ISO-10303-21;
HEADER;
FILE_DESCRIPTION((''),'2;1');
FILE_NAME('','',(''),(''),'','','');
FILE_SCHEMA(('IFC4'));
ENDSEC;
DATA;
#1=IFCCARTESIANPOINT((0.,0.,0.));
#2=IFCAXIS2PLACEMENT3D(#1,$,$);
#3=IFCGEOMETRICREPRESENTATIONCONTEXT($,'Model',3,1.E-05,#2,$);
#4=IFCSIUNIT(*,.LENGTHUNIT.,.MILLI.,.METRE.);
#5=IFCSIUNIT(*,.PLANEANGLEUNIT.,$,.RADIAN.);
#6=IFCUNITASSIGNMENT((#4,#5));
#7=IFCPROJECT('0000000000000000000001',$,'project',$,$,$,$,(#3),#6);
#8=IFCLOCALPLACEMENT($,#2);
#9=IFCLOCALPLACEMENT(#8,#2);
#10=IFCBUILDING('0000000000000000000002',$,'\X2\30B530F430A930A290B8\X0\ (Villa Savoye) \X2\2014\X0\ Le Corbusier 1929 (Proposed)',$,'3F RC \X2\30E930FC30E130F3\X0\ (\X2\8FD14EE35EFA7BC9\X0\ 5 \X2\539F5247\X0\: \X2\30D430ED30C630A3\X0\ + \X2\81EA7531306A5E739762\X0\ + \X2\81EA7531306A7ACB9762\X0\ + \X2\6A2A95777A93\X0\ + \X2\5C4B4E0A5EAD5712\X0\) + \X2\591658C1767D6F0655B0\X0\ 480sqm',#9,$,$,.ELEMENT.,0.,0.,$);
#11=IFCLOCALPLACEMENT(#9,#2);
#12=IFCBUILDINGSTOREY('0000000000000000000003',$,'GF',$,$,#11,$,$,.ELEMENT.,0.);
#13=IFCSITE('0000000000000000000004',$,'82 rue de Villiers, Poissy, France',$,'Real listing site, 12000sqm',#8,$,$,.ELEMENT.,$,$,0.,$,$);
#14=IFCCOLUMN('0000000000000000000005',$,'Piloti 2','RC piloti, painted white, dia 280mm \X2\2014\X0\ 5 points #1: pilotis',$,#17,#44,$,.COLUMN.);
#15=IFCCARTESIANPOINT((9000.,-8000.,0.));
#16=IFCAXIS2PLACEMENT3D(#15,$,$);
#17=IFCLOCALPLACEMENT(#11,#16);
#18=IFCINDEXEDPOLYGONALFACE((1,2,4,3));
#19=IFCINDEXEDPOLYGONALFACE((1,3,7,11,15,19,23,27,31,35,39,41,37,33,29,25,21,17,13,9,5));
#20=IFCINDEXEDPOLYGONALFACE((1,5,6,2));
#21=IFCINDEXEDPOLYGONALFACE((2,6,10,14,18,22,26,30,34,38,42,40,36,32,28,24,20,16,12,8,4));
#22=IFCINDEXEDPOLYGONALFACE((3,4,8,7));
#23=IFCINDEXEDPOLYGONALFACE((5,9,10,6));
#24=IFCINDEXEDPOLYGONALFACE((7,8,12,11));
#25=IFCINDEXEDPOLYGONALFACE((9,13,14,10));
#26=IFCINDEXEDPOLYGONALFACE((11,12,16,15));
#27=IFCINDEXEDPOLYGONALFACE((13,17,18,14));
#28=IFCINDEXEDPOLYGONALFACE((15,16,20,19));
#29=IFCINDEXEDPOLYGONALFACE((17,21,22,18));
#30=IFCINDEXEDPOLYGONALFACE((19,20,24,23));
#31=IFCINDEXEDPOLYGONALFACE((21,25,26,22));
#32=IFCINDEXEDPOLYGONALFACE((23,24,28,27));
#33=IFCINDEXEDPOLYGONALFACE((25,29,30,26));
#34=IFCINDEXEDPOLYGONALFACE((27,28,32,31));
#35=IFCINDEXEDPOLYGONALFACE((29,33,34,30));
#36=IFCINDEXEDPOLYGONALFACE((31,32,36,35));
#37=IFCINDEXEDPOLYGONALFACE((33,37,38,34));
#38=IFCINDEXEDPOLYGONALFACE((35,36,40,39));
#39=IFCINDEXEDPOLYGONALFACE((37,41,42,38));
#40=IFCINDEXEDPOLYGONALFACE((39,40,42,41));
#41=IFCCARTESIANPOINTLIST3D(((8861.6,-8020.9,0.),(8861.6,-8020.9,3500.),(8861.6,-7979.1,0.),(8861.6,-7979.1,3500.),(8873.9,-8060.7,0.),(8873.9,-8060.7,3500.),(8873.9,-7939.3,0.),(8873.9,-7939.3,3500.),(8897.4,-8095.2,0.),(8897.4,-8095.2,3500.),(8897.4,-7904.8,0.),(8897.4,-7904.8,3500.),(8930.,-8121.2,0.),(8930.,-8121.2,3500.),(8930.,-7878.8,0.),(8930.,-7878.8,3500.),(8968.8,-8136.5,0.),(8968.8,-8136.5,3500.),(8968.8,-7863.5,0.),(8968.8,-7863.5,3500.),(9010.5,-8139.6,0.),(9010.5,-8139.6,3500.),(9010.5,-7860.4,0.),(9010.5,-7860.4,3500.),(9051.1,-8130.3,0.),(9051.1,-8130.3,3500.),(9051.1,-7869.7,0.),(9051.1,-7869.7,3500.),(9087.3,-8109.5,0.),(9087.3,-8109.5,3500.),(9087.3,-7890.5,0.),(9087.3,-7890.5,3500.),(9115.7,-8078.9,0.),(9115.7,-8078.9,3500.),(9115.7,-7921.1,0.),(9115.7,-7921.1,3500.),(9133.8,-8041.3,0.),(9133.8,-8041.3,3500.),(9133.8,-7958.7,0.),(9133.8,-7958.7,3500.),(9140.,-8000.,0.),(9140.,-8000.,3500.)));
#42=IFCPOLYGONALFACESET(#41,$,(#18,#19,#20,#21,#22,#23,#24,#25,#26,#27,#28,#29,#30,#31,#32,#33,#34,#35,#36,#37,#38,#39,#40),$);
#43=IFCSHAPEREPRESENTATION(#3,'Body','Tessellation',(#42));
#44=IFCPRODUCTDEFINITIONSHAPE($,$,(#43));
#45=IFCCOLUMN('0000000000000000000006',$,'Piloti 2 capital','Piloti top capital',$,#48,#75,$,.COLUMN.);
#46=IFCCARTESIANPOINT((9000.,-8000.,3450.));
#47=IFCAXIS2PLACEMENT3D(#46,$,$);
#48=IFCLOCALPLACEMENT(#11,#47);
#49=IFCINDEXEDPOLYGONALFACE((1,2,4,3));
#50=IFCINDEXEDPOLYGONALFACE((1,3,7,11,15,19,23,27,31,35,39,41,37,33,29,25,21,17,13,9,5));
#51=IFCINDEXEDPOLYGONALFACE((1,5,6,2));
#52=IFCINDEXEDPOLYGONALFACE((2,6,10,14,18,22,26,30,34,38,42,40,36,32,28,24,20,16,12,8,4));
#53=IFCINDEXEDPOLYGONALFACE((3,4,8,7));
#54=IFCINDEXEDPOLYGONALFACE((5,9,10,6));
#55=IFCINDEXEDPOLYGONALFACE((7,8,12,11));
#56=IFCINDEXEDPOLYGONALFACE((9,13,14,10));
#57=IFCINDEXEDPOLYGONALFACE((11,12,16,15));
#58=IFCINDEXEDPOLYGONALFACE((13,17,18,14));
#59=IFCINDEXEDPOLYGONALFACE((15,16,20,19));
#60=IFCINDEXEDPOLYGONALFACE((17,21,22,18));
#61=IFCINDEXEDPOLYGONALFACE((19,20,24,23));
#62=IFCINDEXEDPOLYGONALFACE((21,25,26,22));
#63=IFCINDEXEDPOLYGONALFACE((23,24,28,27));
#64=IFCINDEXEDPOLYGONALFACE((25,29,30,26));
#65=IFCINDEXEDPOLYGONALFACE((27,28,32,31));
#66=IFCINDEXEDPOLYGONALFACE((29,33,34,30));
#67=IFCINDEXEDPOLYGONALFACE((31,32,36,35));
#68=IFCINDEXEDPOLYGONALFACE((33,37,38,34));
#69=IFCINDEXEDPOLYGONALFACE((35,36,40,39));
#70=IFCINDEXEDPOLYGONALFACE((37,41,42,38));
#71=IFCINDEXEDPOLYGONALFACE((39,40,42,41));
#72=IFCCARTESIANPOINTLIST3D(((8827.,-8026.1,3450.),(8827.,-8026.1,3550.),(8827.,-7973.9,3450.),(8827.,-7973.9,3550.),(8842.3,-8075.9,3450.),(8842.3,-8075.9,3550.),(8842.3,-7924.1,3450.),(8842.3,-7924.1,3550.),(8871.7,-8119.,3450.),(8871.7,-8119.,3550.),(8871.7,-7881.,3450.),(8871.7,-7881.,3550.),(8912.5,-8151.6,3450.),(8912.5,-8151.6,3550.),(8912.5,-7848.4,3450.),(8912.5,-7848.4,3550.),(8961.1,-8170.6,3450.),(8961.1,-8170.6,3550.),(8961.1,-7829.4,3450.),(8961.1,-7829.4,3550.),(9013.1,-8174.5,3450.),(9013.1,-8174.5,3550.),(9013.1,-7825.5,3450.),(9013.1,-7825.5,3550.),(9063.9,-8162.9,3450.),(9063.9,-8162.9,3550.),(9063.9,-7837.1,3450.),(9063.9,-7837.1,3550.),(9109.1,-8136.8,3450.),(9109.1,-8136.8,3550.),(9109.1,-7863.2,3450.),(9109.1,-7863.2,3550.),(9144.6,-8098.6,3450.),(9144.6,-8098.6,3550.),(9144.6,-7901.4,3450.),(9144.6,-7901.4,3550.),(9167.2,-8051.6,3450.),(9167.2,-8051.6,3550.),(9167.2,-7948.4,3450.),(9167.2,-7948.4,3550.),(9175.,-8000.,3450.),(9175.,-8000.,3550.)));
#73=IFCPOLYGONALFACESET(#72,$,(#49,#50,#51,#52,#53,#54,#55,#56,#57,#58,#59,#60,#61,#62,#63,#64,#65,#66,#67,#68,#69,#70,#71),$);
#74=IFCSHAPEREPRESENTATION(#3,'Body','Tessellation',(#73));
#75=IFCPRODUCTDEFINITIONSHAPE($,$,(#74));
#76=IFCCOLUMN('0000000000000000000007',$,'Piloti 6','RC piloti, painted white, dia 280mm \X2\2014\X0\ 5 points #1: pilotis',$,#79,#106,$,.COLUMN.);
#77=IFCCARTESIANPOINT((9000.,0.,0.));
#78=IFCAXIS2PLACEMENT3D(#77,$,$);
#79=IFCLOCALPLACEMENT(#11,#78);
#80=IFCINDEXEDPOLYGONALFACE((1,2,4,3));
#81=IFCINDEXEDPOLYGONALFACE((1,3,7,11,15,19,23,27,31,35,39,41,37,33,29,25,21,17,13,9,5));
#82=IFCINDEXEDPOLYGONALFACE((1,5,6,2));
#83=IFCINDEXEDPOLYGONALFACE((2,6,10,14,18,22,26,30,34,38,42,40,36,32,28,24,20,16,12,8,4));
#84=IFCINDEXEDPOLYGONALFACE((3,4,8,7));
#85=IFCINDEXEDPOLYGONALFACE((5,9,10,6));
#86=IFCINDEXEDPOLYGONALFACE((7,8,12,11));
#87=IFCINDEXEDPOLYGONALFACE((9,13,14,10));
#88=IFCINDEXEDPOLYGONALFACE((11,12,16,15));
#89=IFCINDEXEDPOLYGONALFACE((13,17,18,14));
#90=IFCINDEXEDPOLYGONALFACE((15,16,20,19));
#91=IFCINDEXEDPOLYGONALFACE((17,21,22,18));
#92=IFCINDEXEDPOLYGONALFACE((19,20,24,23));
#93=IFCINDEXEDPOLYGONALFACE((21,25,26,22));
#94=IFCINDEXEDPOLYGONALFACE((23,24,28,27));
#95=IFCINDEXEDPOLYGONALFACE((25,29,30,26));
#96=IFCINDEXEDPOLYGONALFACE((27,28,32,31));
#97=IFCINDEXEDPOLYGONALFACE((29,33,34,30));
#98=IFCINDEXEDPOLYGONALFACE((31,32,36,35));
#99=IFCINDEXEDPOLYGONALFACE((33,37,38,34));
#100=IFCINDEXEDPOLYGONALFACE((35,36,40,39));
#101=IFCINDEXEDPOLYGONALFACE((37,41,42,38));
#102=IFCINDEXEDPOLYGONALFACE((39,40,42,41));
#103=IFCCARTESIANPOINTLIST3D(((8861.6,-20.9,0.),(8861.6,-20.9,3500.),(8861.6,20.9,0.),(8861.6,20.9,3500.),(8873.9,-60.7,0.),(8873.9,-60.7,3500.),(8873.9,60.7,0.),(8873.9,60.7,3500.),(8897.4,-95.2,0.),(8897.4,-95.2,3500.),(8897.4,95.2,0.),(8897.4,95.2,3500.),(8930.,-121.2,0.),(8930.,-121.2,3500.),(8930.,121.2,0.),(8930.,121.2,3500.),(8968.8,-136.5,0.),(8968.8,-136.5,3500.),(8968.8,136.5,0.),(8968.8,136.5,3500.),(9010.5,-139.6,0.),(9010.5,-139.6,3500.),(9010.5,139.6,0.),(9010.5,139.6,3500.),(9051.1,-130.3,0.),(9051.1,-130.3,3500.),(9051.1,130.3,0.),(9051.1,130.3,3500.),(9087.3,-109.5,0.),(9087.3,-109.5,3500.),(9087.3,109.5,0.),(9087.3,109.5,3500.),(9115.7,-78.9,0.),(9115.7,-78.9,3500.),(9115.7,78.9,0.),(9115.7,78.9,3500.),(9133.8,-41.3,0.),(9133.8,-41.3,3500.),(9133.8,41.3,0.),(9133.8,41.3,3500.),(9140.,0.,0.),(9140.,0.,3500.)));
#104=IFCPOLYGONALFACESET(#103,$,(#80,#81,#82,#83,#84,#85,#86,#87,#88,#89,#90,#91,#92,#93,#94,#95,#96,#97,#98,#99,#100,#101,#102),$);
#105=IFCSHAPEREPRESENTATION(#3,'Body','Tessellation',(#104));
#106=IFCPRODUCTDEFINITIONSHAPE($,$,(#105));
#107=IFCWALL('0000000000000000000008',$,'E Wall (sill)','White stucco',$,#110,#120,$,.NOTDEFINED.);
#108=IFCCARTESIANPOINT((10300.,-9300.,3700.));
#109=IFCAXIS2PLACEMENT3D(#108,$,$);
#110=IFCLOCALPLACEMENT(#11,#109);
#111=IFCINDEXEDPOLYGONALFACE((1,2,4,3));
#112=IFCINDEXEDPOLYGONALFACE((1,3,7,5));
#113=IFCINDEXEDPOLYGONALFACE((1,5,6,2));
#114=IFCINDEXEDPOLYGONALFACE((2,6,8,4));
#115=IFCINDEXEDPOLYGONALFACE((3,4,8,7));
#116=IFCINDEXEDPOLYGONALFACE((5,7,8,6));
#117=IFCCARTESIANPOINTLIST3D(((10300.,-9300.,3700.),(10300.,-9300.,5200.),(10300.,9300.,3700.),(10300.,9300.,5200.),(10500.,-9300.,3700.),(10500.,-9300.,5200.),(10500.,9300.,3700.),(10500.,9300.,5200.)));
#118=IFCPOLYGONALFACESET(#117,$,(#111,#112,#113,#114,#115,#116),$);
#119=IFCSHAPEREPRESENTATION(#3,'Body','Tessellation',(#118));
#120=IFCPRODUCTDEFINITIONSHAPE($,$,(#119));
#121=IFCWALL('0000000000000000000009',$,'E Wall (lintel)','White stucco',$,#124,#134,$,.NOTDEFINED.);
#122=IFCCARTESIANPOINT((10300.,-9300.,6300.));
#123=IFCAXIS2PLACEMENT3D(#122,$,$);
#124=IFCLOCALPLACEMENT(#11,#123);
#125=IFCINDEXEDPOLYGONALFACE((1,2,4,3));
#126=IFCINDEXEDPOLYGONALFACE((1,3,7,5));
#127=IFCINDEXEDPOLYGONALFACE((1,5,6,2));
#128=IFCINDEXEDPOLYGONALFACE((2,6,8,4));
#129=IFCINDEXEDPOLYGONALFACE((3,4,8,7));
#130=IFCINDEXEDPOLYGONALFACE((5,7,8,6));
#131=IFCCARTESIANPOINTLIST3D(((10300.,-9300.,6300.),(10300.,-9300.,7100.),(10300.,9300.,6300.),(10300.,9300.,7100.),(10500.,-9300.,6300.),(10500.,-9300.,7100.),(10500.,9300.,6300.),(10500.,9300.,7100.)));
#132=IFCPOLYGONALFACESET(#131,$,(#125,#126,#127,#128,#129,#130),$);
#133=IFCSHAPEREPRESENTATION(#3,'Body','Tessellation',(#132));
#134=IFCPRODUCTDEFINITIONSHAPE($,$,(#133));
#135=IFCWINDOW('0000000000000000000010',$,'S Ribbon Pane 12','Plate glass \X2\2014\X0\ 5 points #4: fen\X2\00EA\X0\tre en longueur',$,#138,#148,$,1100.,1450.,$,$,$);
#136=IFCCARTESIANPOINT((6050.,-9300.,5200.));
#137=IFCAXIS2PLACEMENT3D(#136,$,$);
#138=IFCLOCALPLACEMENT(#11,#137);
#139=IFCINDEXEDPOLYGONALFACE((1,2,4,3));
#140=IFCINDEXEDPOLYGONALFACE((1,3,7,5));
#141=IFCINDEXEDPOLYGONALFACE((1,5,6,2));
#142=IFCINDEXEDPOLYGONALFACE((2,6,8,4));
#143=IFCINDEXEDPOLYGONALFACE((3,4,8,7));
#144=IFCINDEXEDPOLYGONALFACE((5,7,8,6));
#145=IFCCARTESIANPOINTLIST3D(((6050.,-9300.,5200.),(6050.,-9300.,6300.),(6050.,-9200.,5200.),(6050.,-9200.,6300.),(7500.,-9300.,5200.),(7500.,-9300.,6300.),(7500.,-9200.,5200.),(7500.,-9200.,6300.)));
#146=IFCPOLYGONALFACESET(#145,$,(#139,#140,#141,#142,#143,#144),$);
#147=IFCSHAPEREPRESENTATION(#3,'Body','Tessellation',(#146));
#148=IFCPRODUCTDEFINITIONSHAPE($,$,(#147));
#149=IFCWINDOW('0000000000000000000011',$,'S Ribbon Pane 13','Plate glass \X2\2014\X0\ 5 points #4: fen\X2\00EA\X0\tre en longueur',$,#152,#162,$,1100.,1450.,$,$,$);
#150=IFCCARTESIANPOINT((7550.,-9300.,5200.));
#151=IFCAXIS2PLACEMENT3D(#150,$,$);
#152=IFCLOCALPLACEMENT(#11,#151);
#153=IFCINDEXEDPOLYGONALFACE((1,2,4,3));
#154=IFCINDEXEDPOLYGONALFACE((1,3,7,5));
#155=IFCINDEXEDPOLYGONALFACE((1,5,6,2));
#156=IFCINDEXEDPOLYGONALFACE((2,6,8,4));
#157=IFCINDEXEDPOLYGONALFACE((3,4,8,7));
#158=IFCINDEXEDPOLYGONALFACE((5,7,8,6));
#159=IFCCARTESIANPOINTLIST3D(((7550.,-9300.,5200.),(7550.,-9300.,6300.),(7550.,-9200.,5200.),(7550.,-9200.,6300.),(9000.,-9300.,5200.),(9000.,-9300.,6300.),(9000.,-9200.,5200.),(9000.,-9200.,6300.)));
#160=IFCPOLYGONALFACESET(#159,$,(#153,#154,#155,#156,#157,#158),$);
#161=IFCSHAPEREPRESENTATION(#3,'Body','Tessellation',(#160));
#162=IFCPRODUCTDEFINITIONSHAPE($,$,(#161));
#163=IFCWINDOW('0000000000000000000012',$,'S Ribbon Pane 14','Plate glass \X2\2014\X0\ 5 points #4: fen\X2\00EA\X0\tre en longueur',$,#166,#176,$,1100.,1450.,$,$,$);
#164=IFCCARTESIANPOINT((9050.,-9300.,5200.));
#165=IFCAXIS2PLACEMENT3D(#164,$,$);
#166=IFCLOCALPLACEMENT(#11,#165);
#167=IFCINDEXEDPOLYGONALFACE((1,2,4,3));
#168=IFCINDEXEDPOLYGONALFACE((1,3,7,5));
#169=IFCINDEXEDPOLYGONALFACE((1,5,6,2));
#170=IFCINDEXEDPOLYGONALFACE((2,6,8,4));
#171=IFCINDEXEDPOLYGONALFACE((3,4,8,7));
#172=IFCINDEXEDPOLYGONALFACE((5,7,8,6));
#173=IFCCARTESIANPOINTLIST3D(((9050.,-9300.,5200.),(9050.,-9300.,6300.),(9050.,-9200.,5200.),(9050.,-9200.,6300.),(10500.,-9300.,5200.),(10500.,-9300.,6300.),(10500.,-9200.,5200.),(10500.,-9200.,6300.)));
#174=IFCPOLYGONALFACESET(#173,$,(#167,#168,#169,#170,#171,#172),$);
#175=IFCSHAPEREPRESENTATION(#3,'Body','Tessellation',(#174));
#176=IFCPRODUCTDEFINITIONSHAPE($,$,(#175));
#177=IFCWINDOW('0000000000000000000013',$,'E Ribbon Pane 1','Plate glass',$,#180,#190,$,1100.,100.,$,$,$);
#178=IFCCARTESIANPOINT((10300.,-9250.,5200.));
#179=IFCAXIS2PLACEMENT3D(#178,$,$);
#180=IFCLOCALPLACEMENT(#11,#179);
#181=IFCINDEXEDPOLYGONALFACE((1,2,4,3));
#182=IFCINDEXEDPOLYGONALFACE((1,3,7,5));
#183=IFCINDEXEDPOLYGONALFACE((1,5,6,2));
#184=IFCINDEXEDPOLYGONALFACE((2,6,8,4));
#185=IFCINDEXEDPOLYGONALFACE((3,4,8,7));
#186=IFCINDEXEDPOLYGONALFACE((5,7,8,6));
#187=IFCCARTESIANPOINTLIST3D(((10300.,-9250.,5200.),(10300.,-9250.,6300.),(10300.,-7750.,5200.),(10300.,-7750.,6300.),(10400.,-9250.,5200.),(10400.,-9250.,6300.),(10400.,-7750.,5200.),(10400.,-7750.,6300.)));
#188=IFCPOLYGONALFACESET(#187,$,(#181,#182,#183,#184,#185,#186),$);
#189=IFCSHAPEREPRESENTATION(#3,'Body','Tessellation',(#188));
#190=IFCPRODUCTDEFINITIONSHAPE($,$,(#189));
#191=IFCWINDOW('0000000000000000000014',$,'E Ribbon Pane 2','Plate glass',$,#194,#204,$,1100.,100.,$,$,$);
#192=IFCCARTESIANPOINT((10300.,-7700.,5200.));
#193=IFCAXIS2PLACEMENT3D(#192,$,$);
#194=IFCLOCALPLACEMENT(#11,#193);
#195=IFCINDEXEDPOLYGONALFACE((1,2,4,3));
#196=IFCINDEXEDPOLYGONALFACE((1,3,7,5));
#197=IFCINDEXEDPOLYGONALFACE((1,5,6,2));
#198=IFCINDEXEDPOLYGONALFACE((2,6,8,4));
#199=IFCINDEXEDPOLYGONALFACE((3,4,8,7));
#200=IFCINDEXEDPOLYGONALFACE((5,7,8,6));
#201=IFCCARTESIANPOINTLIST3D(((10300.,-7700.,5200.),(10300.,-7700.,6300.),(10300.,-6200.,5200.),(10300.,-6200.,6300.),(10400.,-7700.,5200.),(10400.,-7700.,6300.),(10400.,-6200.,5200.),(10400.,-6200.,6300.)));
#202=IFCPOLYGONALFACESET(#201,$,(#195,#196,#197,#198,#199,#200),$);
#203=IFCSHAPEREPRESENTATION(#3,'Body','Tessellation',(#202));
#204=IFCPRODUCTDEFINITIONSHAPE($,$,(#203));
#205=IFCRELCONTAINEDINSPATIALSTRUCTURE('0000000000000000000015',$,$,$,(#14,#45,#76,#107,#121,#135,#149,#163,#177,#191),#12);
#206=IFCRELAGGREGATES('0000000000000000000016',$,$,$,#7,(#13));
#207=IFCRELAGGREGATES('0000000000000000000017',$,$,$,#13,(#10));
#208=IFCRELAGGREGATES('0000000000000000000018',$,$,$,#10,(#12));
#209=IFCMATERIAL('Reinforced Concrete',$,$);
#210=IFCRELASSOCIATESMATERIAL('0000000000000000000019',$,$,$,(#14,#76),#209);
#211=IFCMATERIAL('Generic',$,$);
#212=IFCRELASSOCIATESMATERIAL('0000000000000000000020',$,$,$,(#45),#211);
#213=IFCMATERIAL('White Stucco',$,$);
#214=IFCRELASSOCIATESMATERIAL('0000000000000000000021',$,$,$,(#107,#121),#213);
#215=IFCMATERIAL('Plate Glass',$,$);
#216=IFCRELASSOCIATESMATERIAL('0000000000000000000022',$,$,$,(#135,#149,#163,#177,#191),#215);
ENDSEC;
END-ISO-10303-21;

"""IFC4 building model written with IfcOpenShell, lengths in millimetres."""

from ifc_helpers import new_model, si_unit, frame, frame_2d, origin, origin_2d, place, context, project, spatial, rectangle, circle, extrude, material, element, save


model = new_model("IFC4")

# Units and contexts
model_context = context("Model", 3, precision=1e-05, world=origin())
ifc_project = project(units=[si_unit("LENGTHUNIT", "METRE", prefix="MILLI"), si_unit("PLANEANGLEUNIT", "RADIAN")], contexts=[model_context])

# Site, building, storey
site_placement = place(None, origin())
site = spatial("IfcSite", under=ifc_project, at=site_placement, Name="82 rue de Villiers, Poissy, France", ObjectType="Real listing site, 12000sqm", CompositionType="ELEMENT", RefElevation=0.0)
building_placement = place(site_placement, origin())
building = spatial("IfcBuilding", under=site, at=building_placement, Name="サヴォア邸 (Villa Savoye) — Le Corbusier 1929 (Proposed)", ObjectType="3F RC ラーメン (近代建築 5 原則: ピロティ + 自由な平面 + 自由な立面 + 横長窓 + 屋上庭園) + 外壁白漆喰 480sqm", CompositionType="ELEMENT", ElevationOfRefHeight=0.0, ElevationOfTerrain=0.0)
storey_placement = place(building_placement, origin())
storey = spatial("IfcBuildingStorey", under=building, at=storey_placement, Name="GF", CompositionType="ELEMENT", Elevation=0.0)

# Columns
ifc_material_1 = material(Name="Reinforced Concrete")
column_1_placement = place(storey_placement, frame((9000.0, -8000.0, 0.0)))
element("IfcColumn", 1, at=column_1_placement, inside=storey, material=ifc_material_1, Name="Piloti 2", Description="RC piloti, painted white, dia 280mm — 5 points #1: pilotis", PredefinedType="COLUMN", context=model_context, shape_type="SweptSolid", body=[
    extrude(circle(Radius=140.0, at=origin_2d()), frame((9000.0, -8000.0, 0.0)), (0.0, 0.0, 1.0), 3500.0),
])
ifc_material_2 = material(Name="Generic")
column_2_placement = place(storey_placement, frame((9000.0, -8000.0, 3450.0)))
element("IfcColumn", 2, at=column_2_placement, inside=storey, material=ifc_material_2, Name="Piloti 2 capital", Description="Piloti top capital", PredefinedType="COLUMN", context=model_context, shape_type="SweptSolid", body=[
    extrude(circle(Radius=175.0, at=origin_2d()), frame((9000.0, -8000.0, 3450.0)), (0.0, 0.0, 1.0), 100.0),
])
column_3_placement = place(storey_placement, frame((9000.0, 0.0, 0.0)))
element("IfcColumn", 3, at=column_3_placement, inside=storey, material=ifc_material_1, Name="Piloti 6", Description="RC piloti, painted white, dia 280mm — 5 points #1: pilotis", PredefinedType="COLUMN", context=model_context, shape_type="SweptSolid", body=[
    extrude(circle(Radius=140.0, at=origin_2d()), frame((9000.0, 0.0, 0.0)), (0.0, 0.0, 1.0), 3500.0),
])

# Walls
ifc_material_3 = material(Name="White Stucco")
wall_1_placement = place(storey_placement, frame((10300.0, -9300.0, 3700.0)))
element("IfcWall", 4, at=wall_1_placement, inside=storey, material=ifc_material_3, Name="E Wall (sill)", Description="White stucco", PredefinedType="NOTDEFINED", context=model_context, shape_type="SweptSolid", body=[
    extrude(rectangle(XDim=200.0, YDim=18600.0, at=frame_2d((100.0, 9300.0))), frame((10300.0, -9300.0, 3700.0)), (0.0, 0.0, 1.0), 1500.0),
])
wall_2_placement = place(storey_placement, frame((10300.0, -9300.0, 6300.0)))
element("IfcWall", 5, at=wall_2_placement, inside=storey, material=ifc_material_3, Name="E Wall (lintel)", Description="White stucco", PredefinedType="NOTDEFINED", context=model_context, shape_type="SweptSolid", body=[
    extrude(rectangle(XDim=200.0, YDim=18600.0, at=frame_2d((100.0, 9300.0))), frame((10300.0, -9300.0, 6300.0)), (0.0, 0.0, 1.0), 800.0),
])

# Windows
ifc_material_4 = material(Name="Plate Glass")
window_1_placement = place(storey_placement, frame((6050.0, -9300.0, 5200.0)))
element("IfcWindow", 6, at=window_1_placement, inside=storey, material=ifc_material_4, Name="S Ribbon Pane 12", Description="Plate glass — 5 points #4: fenêtre en longueur", OverallHeight=1100.0, OverallWidth=1450.0, context=model_context, shape_type="SweptSolid", body=[
    extrude(rectangle(XDim=1450.0, YDim=100.0, at=frame_2d((725.0, 50.0))), frame((6050.0, -9300.0, 5200.0)), (0.0, 0.0, 1.0), 1100.0),
])
window_2_placement = place(storey_placement, frame((7550.0, -9300.0, 5200.0)))
element("IfcWindow", 7, at=window_2_placement, inside=storey, material=ifc_material_4, Name="S Ribbon Pane 13", Description="Plate glass — 5 points #4: fenêtre en longueur", OverallHeight=1100.0, OverallWidth=1450.0, context=model_context, shape_type="SweptSolid", body=[
    extrude(rectangle(XDim=1450.0, YDim=100.0, at=frame_2d((725.0, 50.0))), frame((7550.0, -9300.0, 5200.0)), (0.0, 0.0, 1.0), 1100.0),
])
window_3_placement = place(storey_placement, frame((9050.0, -9300.0, 5200.0)))
element("IfcWindow", 8, at=window_3_placement, inside=storey, material=ifc_material_4, Name="S Ribbon Pane 14", Description="Plate glass — 5 points #4: fenêtre en longueur", OverallHeight=1100.0, OverallWidth=1450.0, context=model_context, shape_type="SweptSolid", body=[
    extrude(rectangle(XDim=1450.0, YDim=100.0, at=frame_2d((725.0, 50.0))), frame((9050.0, -9300.0, 5200.0)), (0.0, 0.0, 1.0), 1100.0),
])
window_4_placement = place(storey_placement, frame((10300.0, -9250.0, 5200.0)))
element("IfcWindow", 9, at=window_4_placement, inside=storey, material=ifc_material_4, Name="E Ribbon Pane 1", Description="Plate glass", OverallHeight=1100.0, OverallWidth=100.0, context=model_context, shape_type="SweptSolid", body=[
    extrude(rectangle(XDim=100.0, YDim=1500.0, at=frame_2d((50.0, 750.0))), frame((10300.0, -9250.0, 5200.0)), (0.0, 0.0, 1.0), 1100.0),
])
window_5_placement = place(storey_placement, frame((10300.0, -7700.0, 5200.0)))
element("IfcWindow", 10, at=window_5_placement, inside=storey, material=ifc_material_4, Name="E Ribbon Pane 2", Description="Plate glass", OverallHeight=1100.0, OverallWidth=100.0, context=model_context, shape_type="SweptSolid", body=[
    extrude(rectangle(XDim=100.0, YDim=1500.0, at=frame_2d((50.0, 750.0))), frame((10300.0, -7700.0, 5200.0)), (0.0, 0.0, 1.0), 1100.0),
])

save(model, "model.ifc")
